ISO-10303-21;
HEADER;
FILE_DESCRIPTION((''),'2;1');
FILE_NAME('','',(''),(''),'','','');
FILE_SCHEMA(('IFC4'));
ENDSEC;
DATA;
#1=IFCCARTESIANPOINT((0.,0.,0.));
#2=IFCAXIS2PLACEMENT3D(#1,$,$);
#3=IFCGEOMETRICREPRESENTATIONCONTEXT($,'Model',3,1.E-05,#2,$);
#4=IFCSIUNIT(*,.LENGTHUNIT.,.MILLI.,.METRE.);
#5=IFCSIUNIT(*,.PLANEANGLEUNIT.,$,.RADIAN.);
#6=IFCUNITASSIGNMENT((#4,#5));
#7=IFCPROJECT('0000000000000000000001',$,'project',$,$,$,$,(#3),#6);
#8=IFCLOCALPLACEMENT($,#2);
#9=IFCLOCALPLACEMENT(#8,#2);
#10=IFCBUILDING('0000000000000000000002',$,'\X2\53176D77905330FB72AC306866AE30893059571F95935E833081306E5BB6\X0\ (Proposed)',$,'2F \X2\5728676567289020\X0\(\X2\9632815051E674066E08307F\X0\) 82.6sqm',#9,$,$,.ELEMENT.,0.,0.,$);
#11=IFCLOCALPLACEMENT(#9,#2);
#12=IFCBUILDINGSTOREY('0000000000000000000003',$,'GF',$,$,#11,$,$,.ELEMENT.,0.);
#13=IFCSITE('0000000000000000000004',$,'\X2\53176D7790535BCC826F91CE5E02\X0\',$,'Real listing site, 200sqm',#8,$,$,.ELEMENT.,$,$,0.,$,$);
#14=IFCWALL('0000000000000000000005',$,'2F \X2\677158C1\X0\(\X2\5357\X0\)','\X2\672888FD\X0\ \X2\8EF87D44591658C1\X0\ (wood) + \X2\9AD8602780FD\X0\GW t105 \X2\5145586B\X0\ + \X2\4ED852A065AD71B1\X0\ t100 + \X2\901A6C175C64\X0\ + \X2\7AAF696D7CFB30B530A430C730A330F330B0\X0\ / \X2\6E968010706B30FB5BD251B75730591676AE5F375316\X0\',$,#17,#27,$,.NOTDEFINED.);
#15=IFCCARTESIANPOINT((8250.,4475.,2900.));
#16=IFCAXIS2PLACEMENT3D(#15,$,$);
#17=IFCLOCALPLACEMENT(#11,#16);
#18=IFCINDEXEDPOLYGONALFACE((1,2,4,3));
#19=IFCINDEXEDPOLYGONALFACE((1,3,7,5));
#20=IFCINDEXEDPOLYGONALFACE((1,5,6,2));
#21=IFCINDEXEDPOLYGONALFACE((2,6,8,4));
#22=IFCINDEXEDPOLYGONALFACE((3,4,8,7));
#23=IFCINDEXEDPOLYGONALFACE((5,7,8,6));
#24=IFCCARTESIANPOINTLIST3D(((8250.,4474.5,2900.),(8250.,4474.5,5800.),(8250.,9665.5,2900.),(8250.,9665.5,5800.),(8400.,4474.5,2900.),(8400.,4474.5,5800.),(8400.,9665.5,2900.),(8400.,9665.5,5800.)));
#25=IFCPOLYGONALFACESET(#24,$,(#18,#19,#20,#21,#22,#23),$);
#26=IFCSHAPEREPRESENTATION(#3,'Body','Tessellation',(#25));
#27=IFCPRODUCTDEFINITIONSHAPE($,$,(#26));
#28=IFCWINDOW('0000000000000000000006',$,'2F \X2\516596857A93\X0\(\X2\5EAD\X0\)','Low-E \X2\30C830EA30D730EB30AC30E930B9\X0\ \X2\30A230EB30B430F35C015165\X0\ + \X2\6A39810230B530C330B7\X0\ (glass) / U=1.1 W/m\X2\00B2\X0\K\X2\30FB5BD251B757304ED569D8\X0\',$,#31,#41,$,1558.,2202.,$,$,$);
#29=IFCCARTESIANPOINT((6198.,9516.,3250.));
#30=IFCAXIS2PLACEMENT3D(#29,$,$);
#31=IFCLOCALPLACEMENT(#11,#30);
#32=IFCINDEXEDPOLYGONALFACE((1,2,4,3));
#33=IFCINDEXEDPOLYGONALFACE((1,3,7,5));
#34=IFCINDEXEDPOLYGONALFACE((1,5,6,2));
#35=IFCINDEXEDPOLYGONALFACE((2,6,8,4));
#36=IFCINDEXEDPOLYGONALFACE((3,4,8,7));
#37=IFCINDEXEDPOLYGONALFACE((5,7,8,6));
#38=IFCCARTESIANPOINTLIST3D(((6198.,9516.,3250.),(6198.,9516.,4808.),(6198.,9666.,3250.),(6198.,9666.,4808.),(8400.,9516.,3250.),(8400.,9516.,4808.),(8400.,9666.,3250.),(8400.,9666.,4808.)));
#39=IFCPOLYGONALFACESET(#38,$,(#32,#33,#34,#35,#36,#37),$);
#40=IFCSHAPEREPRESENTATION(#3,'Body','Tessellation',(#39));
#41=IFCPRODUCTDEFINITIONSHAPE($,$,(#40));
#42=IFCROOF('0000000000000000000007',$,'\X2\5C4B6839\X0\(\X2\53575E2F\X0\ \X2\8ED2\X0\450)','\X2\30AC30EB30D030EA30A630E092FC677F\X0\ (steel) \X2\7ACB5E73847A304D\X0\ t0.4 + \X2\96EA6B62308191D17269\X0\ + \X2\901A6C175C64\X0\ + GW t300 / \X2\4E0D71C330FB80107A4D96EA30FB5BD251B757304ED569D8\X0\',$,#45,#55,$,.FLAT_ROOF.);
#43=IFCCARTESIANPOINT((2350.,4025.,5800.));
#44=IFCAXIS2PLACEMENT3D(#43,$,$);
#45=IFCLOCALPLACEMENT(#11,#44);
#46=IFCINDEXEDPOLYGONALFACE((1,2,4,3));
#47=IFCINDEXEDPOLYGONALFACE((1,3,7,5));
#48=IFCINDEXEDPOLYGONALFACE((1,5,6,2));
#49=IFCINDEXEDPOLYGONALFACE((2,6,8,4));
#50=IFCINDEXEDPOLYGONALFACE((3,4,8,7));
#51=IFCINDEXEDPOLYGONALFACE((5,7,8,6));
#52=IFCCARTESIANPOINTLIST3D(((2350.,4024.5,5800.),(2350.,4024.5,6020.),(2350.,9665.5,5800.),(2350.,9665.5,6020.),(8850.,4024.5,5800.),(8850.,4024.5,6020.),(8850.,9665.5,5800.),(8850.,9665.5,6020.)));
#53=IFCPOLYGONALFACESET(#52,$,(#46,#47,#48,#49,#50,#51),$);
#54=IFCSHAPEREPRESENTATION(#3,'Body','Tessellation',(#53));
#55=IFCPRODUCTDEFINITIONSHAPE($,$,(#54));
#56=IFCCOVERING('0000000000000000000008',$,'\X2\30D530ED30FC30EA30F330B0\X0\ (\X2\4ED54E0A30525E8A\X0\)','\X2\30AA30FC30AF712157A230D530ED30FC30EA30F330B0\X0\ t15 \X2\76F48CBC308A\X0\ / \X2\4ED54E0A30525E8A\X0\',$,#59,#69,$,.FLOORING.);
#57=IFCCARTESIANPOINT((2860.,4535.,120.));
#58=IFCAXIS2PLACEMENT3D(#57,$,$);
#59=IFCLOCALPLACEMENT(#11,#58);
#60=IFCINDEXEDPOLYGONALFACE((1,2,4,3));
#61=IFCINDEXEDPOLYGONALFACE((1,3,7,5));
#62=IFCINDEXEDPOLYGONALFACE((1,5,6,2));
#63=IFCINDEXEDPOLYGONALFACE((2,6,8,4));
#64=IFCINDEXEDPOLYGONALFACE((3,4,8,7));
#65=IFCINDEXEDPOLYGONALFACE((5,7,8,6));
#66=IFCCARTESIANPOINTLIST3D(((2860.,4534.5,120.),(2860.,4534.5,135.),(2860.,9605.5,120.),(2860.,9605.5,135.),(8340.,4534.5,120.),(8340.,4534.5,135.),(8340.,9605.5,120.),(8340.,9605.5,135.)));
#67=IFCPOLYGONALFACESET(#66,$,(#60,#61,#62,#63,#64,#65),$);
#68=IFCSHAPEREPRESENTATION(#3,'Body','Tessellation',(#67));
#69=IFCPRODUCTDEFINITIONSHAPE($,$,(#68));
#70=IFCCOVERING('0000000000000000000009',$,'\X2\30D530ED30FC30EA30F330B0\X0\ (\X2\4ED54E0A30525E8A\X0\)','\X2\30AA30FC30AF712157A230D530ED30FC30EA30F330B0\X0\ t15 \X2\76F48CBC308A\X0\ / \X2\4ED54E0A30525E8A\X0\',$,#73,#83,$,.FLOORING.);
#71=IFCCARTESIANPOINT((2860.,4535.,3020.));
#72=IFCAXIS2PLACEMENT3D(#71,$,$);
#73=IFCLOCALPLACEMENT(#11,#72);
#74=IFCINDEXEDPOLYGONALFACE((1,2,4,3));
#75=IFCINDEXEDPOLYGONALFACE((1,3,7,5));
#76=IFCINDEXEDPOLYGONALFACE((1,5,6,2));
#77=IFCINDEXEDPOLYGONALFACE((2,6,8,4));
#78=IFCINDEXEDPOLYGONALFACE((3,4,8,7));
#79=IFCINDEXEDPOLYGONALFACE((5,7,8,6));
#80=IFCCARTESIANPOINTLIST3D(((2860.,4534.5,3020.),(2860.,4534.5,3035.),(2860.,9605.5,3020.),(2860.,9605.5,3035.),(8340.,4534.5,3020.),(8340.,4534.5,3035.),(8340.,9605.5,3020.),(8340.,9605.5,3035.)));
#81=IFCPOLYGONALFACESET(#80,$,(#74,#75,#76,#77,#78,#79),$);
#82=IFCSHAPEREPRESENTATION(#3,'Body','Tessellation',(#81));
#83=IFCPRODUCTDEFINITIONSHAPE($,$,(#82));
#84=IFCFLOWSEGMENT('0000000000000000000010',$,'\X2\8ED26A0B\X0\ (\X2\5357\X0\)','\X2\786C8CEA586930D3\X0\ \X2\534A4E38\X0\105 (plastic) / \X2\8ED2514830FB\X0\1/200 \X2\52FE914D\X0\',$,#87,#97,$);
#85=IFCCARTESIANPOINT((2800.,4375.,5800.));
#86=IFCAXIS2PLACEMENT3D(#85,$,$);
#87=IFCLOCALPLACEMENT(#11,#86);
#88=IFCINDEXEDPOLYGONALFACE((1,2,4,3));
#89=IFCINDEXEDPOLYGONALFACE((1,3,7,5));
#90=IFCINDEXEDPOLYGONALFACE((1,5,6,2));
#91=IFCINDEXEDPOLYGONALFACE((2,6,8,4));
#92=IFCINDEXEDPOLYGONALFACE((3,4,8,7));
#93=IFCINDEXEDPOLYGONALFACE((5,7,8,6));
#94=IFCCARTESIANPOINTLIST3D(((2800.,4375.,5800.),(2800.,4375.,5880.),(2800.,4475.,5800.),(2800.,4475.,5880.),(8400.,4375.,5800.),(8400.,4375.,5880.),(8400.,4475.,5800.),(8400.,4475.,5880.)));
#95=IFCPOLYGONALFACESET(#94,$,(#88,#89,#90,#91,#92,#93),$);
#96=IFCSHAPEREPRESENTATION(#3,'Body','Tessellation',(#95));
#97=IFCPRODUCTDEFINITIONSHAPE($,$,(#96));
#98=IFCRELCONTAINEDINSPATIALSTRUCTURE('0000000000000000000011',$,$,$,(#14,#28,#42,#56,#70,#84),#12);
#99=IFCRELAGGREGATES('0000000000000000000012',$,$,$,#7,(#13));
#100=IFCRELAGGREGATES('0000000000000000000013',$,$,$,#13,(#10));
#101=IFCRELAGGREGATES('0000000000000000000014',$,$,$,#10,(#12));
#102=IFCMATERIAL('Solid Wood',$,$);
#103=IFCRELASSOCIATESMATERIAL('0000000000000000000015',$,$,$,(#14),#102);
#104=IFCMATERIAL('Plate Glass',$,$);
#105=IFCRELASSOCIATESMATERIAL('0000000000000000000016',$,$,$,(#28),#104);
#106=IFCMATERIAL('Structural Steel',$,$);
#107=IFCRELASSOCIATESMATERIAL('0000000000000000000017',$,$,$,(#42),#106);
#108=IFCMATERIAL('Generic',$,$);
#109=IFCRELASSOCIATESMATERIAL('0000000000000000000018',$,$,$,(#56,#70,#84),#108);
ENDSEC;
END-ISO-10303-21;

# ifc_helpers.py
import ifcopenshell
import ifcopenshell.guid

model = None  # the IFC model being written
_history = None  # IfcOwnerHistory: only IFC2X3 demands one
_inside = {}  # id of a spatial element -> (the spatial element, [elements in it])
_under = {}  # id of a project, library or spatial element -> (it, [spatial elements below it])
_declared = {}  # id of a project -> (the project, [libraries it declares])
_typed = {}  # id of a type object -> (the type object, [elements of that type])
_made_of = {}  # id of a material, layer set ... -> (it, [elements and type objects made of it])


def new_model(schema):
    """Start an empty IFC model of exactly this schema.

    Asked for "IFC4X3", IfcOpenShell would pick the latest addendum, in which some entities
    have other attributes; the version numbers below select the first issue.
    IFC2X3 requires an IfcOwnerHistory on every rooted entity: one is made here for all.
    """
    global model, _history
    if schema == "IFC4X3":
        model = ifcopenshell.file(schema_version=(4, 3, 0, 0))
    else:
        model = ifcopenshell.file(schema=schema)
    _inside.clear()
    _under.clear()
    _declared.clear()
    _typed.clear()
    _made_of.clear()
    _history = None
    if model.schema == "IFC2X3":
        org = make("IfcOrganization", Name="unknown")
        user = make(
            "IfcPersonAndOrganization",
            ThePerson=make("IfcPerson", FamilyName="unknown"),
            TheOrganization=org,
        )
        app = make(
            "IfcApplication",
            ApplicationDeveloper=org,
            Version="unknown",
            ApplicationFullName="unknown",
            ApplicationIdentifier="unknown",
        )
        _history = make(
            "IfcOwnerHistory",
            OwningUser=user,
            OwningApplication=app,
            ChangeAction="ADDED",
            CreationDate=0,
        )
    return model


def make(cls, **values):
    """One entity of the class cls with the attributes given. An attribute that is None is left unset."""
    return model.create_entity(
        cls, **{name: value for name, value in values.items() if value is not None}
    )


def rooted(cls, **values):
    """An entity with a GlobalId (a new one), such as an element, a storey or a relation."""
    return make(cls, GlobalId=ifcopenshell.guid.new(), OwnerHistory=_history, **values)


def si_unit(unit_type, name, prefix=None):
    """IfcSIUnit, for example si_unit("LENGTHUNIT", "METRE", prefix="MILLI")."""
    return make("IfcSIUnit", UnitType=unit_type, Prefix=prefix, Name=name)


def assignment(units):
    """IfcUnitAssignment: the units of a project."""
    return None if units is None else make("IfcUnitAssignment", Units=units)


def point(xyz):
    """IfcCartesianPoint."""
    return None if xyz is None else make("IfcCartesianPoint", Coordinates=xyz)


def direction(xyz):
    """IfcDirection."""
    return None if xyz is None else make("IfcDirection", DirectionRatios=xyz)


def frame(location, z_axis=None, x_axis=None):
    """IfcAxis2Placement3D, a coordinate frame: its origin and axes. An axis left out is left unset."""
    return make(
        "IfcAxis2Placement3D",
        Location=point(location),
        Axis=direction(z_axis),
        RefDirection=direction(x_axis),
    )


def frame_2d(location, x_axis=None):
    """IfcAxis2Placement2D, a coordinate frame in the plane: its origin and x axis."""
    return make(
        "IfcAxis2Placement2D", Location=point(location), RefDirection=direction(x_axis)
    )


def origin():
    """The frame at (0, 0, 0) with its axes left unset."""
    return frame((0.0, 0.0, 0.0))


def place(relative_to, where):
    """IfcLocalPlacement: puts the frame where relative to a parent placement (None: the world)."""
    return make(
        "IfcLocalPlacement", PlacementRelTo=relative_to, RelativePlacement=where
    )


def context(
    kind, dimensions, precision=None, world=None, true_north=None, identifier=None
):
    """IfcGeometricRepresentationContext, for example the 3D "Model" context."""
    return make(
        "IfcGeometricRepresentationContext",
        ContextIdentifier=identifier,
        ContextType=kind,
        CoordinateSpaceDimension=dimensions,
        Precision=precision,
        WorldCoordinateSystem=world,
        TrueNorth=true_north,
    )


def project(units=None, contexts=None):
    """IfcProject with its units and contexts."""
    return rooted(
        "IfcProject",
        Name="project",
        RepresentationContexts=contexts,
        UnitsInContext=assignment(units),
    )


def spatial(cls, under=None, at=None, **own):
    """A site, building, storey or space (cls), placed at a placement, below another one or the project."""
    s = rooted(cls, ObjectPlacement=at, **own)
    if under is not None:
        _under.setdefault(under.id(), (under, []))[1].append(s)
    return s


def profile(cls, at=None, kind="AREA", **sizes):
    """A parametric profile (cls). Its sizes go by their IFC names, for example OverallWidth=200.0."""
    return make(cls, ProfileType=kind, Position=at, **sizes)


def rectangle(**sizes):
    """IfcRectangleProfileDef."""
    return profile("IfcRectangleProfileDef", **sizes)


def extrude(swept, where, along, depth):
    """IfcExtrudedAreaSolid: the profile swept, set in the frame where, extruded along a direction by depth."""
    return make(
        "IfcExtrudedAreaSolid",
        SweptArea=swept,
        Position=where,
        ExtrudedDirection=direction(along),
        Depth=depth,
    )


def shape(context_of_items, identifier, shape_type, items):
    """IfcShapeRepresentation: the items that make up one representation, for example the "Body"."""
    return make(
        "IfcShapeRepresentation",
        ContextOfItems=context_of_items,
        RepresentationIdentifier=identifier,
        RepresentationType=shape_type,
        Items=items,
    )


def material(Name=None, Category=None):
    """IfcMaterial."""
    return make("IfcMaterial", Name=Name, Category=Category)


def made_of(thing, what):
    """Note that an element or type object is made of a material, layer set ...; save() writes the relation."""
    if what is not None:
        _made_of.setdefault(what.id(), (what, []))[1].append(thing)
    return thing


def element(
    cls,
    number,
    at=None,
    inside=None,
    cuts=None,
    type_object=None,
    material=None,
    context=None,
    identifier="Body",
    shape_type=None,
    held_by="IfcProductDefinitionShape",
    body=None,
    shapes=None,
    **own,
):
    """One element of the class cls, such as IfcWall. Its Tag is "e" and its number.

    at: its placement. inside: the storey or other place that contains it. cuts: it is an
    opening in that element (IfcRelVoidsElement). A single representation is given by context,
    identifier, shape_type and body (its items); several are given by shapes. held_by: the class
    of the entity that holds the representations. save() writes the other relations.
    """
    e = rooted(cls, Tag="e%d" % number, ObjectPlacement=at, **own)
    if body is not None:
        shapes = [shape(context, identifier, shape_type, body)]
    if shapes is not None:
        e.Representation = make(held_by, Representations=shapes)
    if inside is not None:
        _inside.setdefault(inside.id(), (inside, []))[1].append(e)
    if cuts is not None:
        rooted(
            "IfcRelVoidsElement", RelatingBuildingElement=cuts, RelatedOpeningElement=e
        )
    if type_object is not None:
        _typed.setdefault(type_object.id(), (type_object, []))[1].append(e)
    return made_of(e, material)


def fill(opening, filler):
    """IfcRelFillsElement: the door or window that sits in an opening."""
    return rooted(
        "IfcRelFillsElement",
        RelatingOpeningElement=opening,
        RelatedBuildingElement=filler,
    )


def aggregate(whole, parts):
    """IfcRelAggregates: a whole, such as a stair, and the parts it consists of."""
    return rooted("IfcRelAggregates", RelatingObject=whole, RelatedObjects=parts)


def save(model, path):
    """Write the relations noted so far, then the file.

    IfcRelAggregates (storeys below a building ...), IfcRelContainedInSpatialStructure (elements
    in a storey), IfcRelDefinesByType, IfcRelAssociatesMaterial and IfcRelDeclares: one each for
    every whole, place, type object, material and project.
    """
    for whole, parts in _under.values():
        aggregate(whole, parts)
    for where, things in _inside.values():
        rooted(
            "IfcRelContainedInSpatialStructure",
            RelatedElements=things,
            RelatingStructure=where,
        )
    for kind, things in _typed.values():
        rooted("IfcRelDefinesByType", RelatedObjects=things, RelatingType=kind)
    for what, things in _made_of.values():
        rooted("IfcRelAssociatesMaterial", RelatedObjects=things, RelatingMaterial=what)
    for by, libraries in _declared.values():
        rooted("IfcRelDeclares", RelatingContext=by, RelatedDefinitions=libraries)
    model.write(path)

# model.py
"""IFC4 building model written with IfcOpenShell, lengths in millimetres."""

from ifc_helpers import new_model, si_unit, frame, frame_2d, origin, place, context, project, spatial, rectangle, extrude, material, element, fill, save


model = new_model("IFC4")

# Units and contexts
model_context = context("Model", 3, precision=1e-05, world=origin())
ifc_project = project(units=[si_unit("LENGTHUNIT", "METRE", prefix="MILLI"), si_unit("PLANEANGLEUNIT", "RADIAN")], contexts=[model_context])

# Site, building, storey
site_placement = place(None, origin())
site = spatial("IfcSite", under=ifc_project, at=site_placement, Name="北海道富良野市", ObjectType="Real listing site, 200sqm", CompositionType="ELEMENT", RefElevation=0.0)
building_placement = place(site_placement, origin())
building = spatial("IfcBuilding", under=site, at=building_placement, Name="北海道・犬と暮らす土間広めの家 (Proposed)", ObjectType="2F 在来木造(防腐処理済み) 82.6sqm", CompositionType="ELEMENT", ElevationOfRefHeight=0.0, ElevationOfTerrain=0.0)
storey_placement = place(building_placement, origin())
storey = spatial("IfcBuildingStorey", under=building, at=storey_placement, Name="GF", CompositionType="ELEMENT", Elevation=0.0)

# Shared definitions
ifc_material_1 = material(Name="Solid Wood")

# Shared definitions
ifc_material_2 = material(Name="Plate Glass")

# Wall, opening, window
wall_1_placement = place(storey_placement, frame((8250.0, 4475.0, 2900.0)))
wall_1 = element("IfcWall", 1, at=wall_1_placement, inside=storey, material=ifc_material_1, Name="2F 東壁(南)", Description="木製 軸組外壁 (wood) + 高性能GW t105 充填 + 付加断熱 t100 + 通気層 + 窯業系サイディング / 準耐火・寒冷地外皮強化", PredefinedType="NOTDEFINED", context=model_context, shape_type="SweptSolid", body=[
    extrude(rectangle(XDim=150.0, YDim=5191.0, at=frame_2d((75.0, 2595.0))), frame((8250.0, 4475.0, 2900.0)), (0.0, 0.0, 1.0), 2900.0),
])
opening_1_placement = place(storey_placement, frame((6198.0, 9516.0, 3250.0)))
opening_1 = element("IfcOpeningElement", 2, at=opening_1_placement, cuts=wall_1, PredefinedType="NOTDEFINED", context=model_context, shape_type="SweptSolid", body=[
    extrude(rectangle(XDim=2202.0, YDim=150.0, at=frame_2d((1101.0, 75.0))), frame((6198.0, 9516.0, 3250.0)), (0.0, 0.0, 1.0), 1558.0),
])
window_1_placement = place(storey_placement, frame((6198.0, 9516.0, 3250.0)))
window_1 = element("IfcWindow", 3, at=window_1_placement, inside=storey, material=ifc_material_2, Name="2F 入隅窓(庭)", Description="Low-E トリプルガラス アルゴン封入 + 樹脂サッシ (glass) / U=1.1 W/m²K・寒冷地仕様", OverallHeight=1558.0, OverallWidth=2202.0, context=model_context, shape_type="SweptSolid", body=[
    extrude(rectangle(XDim=2202.0, YDim=150.0, at=frame_2d((1101.0, 75.0))), frame((6198.0, 9516.0, 3250.0)), (0.0, 0.0, 1.0), 1558.0),
])
fill(opening_1, window_1)

# Roof
ifc_material_3 = material(Name="Structural Steel")
for number, where, name in (
    (4, (2350.0, 4025.0, 5800.0), "屋根(南帯 軒450)"),
):
    element("IfcRoof", number, at=place(storey_placement, frame(where)), inside=storey, material=ifc_material_3, Name=name, Description="ガルバリウム鋼板 (steel) 立平葺き t0.4 + 雪止め金物 + 通気層 + GW t300 / 不燃・耐積雪・寒冷地仕様", PredefinedType="FLAT_ROOF", context=model_context, shape_type="SweptSolid", body=[
        extrude(rectangle(XDim=6500.0, YDim=5641.0, at=frame_2d((3250.0, 2820.0))), frame((2350.0, 4025.0, 5800.0)), (0.0, 0.0, 1.0), 220.0),
    ])

# Coverings
ifc_material_4 = material(Name="Generic")
covering_1_placement = place(storey_placement, frame((2860.0, 4535.0, 120.0)))
element("IfcCovering", 5, at=covering_1_placement, inside=storey, material=ifc_material_4, Name="フローリング (仕上げ床)", Description="オーク無垢フローリング t15 直貼り / 仕上げ床", PredefinedType="FLOORING", context=model_context, shape_type="SweptSolid", body=[
    extrude(rectangle(XDim=5480.0, YDim=5071.0, at=frame_2d((2740.0, 2535.0))), frame((2860.0, 4535.0, 120.0)), (0.0, 0.0, 1.0), 15.0),
])
covering_2_placement = place(storey_placement, frame((2860.0, 4535.0, 3020.0)))
element("IfcCovering", 6, at=covering_2_placement, inside=storey, material=ifc_material_4, Name="フローリング (仕上げ床)", Description="オーク無垢フローリング t15 直貼り / 仕上げ床", PredefinedType="FLOORING", context=model_context, shape_type="SweptSolid", body=[
    extrude(rectangle(XDim=5480.0, YDim=5071.0, at=frame_2d((2740.0, 2535.0))), frame((2860.0, 4535.0, 3020.0)), (0.0, 0.0, 1.0), 15.0),
])

# Flow segment
flow_segment_placement = place(storey_placement, frame((2800.0, 4375.0, 5800.0)))
element("IfcFlowSegment", 7, at=flow_segment_placement, inside=storey, material=ifc_material_4, Name="軒樋 (南)", Description="硬質塩ビ 半丸105 (plastic) / 軒先・1/200 勾配", context=model_context, shape_type="SweptSolid", body=[
    extrude(rectangle(XDim=5600.0, YDim=100.0, at=frame_2d((2800.0, 50.0))), frame((2800.0, 4375.0, 5800.0)), (0.0, 0.0, 1.0), 80.0),
])

save(model, "model.ifc")
